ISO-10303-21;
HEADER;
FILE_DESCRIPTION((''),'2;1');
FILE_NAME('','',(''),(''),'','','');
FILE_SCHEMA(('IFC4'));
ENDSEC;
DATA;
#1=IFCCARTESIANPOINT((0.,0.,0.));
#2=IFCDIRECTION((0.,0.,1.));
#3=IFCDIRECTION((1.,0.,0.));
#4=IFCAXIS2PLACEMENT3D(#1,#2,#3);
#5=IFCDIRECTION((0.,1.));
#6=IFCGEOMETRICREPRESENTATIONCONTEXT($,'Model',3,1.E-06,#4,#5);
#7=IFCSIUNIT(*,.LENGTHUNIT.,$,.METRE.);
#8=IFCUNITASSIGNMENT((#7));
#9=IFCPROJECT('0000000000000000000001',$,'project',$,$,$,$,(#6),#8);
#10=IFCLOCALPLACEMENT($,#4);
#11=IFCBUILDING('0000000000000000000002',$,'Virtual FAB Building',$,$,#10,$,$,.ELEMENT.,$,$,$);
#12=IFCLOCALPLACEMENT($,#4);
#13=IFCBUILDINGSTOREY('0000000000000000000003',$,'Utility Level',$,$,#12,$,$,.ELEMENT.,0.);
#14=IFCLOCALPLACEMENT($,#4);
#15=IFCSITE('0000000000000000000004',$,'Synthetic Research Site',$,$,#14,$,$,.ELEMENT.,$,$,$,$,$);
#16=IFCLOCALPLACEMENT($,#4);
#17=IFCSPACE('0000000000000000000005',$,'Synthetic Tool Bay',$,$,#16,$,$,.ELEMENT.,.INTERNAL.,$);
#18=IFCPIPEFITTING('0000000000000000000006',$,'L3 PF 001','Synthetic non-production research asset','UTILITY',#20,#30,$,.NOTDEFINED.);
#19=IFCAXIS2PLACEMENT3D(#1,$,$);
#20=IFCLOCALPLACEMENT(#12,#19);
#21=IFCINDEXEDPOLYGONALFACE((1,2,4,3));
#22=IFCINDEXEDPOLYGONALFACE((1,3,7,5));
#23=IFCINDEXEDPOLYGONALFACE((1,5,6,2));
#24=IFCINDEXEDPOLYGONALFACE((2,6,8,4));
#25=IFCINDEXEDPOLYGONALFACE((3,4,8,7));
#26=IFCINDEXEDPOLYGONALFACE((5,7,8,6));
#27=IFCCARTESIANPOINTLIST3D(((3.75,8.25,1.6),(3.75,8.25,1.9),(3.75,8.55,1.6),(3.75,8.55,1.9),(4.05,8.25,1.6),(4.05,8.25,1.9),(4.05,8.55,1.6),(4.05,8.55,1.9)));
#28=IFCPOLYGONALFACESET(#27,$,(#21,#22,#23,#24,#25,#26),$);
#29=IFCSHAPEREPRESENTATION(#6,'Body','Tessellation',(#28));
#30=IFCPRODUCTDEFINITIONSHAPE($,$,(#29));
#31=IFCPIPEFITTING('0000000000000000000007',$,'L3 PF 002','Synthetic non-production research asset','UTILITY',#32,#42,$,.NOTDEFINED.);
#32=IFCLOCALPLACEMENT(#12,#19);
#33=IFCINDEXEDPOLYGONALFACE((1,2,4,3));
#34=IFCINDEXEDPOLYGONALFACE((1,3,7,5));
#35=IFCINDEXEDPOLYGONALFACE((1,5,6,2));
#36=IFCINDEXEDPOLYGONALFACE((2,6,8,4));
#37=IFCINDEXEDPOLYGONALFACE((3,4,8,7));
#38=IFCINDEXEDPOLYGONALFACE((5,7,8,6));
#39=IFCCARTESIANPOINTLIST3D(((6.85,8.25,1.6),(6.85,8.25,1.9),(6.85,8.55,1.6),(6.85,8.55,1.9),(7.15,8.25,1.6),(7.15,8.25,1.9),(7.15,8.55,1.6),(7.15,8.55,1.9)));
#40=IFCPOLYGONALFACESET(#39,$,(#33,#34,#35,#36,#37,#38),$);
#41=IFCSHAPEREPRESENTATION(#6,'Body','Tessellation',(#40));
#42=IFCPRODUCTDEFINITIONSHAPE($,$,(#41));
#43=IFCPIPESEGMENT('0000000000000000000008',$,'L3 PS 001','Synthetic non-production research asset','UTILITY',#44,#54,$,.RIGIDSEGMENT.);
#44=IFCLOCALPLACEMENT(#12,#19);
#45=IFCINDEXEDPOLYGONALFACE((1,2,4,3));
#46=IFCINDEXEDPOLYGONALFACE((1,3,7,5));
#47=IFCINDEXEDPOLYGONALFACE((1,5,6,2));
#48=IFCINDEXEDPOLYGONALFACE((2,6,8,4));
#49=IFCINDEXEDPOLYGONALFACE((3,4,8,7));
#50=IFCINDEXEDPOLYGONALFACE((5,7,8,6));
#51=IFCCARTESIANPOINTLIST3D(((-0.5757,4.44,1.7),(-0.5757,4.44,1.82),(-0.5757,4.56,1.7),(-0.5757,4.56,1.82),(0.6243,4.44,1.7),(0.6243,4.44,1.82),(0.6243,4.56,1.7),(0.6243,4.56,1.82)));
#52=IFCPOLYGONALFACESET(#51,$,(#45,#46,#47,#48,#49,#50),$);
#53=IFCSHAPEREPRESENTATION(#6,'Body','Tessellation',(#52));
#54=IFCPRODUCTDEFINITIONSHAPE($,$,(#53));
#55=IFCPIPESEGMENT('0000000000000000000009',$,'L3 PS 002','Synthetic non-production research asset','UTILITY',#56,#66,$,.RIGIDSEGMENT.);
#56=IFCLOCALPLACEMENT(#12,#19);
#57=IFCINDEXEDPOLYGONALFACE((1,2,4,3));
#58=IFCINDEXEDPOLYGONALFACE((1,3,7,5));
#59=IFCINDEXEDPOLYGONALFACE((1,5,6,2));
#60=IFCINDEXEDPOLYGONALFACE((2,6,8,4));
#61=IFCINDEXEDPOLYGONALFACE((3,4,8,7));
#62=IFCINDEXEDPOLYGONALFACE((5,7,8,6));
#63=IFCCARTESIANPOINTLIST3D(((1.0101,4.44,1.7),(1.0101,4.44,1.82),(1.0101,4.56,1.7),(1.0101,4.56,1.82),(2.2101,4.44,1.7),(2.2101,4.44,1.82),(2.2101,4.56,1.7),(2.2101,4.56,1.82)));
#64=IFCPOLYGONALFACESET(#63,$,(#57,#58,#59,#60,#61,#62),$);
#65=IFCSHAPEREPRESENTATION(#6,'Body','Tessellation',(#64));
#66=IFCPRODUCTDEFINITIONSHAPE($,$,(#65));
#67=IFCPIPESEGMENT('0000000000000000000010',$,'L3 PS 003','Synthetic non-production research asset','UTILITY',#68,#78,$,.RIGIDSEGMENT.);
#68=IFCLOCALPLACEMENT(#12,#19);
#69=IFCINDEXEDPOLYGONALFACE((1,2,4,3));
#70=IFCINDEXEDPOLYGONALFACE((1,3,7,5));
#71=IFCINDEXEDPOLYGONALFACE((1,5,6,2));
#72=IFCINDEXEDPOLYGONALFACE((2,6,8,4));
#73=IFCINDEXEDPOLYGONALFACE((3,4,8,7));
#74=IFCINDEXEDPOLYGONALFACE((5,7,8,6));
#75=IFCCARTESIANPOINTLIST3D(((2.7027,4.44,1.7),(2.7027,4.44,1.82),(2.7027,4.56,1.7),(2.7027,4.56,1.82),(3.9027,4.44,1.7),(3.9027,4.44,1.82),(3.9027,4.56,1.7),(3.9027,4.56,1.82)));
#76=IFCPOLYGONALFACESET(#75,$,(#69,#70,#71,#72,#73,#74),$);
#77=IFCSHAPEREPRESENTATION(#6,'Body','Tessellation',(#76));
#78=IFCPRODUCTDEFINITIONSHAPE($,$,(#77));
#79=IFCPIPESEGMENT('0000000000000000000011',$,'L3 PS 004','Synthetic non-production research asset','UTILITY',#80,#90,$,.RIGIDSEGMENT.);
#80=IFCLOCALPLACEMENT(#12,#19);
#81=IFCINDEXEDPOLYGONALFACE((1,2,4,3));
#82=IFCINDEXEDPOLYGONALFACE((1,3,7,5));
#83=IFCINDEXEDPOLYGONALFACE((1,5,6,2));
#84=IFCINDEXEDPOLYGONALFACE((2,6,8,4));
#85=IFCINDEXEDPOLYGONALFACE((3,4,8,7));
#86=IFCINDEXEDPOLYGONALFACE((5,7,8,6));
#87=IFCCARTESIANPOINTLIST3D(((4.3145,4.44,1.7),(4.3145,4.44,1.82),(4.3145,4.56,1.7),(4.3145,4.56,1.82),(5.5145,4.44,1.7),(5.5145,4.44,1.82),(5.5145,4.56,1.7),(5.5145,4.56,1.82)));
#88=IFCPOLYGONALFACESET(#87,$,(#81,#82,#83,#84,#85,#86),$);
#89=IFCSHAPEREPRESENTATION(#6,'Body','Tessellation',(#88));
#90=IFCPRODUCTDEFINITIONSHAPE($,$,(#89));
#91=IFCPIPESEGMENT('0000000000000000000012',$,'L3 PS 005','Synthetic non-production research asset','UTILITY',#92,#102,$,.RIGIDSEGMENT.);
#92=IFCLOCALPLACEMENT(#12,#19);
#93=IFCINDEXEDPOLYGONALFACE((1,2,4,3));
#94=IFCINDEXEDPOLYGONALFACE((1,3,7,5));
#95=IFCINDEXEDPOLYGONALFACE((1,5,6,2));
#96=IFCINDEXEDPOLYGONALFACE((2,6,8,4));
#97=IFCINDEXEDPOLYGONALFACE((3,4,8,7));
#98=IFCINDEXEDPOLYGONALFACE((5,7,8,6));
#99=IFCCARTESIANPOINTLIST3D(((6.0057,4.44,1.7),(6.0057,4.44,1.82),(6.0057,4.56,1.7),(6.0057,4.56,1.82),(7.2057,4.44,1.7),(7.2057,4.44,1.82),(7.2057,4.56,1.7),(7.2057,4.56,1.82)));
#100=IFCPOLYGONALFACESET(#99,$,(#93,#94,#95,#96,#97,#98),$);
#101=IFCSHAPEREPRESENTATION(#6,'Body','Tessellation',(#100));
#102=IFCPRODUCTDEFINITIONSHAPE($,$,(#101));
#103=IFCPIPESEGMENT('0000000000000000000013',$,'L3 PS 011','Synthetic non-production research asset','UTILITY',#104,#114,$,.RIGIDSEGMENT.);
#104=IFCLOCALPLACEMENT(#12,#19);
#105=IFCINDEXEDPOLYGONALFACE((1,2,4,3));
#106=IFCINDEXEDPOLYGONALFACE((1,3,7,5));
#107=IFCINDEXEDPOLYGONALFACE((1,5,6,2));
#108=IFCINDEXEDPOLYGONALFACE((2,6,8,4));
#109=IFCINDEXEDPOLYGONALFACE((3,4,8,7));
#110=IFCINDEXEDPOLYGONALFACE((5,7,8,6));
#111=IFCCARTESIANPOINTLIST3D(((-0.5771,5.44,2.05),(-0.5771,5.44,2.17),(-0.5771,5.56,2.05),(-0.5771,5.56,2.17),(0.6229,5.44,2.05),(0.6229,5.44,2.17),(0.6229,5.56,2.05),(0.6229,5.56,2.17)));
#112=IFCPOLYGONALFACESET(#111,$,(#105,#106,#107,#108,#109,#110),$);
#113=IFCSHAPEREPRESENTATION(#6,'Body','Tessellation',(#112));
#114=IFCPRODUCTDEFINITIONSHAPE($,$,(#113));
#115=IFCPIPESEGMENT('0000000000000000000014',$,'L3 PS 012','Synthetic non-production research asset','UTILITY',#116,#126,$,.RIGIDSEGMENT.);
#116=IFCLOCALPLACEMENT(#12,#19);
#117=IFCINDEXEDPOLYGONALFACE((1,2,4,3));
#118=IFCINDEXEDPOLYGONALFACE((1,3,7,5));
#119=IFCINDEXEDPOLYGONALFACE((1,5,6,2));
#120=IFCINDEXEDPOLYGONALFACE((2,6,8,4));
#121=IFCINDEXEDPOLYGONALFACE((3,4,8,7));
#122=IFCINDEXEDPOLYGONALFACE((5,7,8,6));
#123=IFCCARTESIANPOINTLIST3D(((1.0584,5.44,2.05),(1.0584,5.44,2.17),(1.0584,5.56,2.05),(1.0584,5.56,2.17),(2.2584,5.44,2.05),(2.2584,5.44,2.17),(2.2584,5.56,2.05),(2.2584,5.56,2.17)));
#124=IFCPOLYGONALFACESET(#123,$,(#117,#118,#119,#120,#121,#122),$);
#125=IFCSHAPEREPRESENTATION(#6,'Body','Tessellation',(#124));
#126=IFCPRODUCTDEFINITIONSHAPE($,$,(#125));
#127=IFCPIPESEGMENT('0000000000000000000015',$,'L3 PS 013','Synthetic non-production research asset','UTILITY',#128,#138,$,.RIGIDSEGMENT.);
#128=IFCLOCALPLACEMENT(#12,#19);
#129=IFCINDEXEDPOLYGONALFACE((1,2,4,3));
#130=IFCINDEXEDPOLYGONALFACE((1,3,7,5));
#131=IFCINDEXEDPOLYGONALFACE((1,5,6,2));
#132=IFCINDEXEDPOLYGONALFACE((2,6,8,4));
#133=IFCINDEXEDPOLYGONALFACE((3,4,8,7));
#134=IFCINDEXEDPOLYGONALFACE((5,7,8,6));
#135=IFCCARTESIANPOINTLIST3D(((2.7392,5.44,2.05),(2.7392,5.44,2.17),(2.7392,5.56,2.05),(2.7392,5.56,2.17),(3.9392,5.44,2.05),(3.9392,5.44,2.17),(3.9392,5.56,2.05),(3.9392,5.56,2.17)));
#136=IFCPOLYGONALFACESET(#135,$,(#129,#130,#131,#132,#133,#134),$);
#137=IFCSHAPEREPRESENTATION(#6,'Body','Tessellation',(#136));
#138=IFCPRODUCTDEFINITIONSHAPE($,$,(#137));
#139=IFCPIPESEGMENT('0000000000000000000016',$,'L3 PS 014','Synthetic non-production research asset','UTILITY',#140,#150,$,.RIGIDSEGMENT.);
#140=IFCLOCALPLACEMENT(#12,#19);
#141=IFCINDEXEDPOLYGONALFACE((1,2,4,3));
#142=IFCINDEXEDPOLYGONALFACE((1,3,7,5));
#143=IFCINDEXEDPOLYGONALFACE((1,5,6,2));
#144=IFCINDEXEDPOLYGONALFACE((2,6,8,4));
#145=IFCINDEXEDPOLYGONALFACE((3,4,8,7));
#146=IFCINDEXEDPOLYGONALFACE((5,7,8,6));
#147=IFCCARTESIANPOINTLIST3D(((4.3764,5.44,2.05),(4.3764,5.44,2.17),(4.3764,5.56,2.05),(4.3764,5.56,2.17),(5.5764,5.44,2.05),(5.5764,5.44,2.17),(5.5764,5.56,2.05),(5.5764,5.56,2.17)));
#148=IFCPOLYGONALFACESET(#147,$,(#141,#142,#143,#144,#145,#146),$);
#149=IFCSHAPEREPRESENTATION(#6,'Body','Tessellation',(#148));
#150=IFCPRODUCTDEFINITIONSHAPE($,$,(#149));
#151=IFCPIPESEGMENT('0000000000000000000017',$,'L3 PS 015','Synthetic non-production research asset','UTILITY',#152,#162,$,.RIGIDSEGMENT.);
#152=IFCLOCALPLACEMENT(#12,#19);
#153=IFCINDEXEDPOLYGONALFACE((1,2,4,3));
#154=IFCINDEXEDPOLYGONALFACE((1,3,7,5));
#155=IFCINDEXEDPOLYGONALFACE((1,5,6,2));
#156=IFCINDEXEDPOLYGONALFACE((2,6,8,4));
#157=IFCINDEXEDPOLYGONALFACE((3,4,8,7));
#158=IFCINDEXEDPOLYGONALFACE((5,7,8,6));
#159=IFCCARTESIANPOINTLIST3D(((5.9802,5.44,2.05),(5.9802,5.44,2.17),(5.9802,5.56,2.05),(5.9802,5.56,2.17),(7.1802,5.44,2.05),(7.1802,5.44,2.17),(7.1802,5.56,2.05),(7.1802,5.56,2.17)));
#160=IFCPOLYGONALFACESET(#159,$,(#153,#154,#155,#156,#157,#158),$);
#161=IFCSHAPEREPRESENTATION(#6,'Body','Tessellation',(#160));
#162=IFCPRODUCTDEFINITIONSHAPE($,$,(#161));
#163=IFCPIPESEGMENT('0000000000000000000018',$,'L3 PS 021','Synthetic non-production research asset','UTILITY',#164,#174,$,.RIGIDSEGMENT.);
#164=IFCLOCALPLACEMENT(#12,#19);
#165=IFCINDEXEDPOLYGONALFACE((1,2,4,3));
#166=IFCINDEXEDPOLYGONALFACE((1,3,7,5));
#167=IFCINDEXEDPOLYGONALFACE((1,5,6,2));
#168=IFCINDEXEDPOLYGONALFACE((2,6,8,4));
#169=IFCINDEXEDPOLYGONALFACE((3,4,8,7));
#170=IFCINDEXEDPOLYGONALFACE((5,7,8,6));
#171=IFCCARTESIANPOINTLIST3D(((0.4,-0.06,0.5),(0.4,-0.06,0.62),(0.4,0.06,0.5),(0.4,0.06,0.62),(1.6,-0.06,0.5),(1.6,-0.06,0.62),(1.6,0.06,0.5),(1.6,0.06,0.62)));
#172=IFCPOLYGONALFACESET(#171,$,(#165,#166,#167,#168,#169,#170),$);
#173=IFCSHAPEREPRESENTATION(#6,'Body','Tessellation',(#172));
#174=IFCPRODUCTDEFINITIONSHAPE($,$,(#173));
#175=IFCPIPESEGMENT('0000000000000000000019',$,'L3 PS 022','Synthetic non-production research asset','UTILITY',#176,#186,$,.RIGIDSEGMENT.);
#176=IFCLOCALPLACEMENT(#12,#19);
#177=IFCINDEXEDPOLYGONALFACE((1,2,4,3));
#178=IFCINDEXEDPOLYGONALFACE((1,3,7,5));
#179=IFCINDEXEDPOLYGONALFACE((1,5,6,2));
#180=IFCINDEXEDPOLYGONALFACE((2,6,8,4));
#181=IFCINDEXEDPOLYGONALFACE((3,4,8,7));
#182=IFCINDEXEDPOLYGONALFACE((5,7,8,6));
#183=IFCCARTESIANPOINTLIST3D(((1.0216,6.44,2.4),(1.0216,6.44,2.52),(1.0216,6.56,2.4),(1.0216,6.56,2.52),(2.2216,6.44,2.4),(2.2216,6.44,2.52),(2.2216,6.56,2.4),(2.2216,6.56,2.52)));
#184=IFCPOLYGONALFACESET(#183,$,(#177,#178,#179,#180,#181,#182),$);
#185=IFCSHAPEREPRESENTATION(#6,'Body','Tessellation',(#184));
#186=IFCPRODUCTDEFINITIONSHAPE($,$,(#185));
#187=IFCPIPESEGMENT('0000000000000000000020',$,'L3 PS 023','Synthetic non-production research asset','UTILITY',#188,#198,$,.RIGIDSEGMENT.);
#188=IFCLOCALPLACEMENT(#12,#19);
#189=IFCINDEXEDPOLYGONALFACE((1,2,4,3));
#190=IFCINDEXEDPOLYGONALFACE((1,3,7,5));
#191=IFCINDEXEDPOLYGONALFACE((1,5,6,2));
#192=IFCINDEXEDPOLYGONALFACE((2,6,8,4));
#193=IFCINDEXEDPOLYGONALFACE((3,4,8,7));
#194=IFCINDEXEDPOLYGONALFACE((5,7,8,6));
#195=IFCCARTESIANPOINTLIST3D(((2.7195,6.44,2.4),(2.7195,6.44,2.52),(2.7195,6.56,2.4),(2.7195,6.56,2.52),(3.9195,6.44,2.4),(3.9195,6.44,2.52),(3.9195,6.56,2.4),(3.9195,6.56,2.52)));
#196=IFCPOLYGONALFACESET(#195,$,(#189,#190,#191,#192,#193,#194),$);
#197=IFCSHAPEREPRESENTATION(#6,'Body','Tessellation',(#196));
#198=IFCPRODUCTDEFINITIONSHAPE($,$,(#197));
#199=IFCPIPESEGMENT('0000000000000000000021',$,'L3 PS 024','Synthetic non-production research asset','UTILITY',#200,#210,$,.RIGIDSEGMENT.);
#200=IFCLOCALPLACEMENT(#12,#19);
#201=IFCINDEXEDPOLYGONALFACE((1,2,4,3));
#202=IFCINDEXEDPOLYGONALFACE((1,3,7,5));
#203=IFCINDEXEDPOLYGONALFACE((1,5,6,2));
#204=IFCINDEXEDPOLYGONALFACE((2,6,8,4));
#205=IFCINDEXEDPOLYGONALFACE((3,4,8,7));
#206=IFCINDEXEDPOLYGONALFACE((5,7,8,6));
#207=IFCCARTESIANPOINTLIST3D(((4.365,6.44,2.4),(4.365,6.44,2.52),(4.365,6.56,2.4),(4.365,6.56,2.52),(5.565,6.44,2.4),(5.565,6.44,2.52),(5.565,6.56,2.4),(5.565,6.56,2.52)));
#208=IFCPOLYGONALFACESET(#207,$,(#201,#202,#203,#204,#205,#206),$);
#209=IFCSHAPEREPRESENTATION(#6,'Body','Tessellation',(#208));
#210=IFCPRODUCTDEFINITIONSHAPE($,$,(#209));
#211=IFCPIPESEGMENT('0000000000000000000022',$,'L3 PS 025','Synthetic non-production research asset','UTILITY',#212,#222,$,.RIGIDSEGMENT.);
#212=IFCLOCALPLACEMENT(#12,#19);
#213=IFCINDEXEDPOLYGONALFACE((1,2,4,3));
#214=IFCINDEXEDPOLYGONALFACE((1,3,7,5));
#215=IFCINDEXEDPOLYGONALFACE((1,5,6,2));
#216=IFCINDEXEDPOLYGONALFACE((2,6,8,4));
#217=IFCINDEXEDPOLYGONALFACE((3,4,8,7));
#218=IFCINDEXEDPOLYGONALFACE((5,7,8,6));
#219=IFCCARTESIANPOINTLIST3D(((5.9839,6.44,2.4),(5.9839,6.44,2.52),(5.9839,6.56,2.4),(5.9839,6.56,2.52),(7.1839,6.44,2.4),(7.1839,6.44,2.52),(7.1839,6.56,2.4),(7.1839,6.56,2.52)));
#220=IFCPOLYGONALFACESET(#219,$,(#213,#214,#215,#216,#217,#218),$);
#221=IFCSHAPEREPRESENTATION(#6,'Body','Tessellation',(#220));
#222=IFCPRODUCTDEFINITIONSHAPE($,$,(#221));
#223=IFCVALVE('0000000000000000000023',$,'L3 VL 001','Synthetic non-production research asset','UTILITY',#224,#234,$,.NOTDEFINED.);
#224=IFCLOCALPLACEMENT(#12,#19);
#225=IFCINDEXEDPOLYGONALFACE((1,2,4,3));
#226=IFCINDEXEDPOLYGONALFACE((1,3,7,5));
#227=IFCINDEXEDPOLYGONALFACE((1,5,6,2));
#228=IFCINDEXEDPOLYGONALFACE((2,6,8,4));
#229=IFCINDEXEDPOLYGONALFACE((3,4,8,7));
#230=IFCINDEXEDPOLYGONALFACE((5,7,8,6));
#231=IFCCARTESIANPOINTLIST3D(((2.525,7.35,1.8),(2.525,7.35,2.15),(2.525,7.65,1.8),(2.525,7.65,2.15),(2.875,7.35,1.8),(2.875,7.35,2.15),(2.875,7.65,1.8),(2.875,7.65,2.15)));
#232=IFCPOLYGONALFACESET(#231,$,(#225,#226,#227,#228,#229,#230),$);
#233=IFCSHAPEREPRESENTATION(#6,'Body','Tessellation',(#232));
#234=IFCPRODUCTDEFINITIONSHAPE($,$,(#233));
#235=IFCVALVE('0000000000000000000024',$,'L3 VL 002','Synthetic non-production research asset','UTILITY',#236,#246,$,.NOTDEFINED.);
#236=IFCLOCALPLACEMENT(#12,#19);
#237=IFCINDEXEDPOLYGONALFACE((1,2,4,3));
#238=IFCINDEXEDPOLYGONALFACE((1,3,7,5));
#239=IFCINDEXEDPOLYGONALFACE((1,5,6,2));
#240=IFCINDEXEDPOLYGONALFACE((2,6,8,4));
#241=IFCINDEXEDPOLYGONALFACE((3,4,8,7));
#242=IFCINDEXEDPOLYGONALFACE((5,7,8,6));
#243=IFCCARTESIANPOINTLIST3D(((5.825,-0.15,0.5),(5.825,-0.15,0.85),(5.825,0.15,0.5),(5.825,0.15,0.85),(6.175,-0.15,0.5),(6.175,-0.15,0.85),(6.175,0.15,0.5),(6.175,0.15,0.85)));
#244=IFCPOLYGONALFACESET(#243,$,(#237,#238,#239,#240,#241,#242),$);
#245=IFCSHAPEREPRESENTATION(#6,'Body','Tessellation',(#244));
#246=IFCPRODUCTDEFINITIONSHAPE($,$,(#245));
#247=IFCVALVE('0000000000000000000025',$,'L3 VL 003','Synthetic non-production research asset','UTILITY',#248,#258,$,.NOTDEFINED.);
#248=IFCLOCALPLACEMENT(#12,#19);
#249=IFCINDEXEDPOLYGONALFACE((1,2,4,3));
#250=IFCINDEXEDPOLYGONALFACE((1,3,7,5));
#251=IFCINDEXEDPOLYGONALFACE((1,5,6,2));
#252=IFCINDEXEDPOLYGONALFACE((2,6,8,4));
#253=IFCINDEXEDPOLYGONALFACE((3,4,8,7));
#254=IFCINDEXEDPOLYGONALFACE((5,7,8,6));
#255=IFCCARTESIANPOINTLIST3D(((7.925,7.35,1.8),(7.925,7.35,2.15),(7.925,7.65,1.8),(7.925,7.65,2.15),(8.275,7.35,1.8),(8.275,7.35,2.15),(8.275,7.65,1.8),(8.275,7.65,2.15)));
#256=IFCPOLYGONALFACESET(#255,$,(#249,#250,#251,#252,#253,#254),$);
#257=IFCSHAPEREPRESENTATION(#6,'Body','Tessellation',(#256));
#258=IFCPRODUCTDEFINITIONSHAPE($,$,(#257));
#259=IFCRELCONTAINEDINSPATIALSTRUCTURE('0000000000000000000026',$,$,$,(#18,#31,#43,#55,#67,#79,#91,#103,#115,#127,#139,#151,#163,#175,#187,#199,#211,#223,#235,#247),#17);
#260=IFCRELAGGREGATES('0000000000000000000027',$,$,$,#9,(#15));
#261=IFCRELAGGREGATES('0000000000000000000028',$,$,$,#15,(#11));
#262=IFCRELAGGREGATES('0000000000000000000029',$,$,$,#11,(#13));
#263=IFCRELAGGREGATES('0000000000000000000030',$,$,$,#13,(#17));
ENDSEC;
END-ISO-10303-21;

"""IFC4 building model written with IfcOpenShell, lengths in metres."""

from ifc_helpers import new_model, si_unit, direction, frame, origin_with_axes, origin_2d_with_axis, place, context, project, spatial, rectangle, extrude, element, save


model = new_model("IFC4")

# Units and contexts
model_context = context("Model", 3, precision=1e-06, world=origin_with_axes(), true_north=direction((0.0, 1.0)))
ifc_project = project(units=[si_unit("LENGTHUNIT", "METRE")], contexts=[model_context])

# Site, building, storey, space
site_placement = place(None, origin_with_axes())
site = spatial("IfcSite", under=ifc_project, at=site_placement, Name="Synthetic Research Site", CompositionType="ELEMENT")
building_placement = place(None, origin_with_axes())
building = spatial("IfcBuilding", under=site, at=building_placement, Name="Virtual FAB Building", CompositionType="ELEMENT")
storey_placement = place(None, origin_with_axes())
storey = spatial("IfcBuildingStorey", under=building, at=storey_placement, Name="Utility Level", CompositionType="ELEMENT", Elevation=0.0)
space_placement = place(None, origin_with_axes())
space = spatial("IfcSpace", under=storey, at=space_placement, Name="Synthetic Tool Bay", CompositionType="ELEMENT", PredefinedType="INTERNAL")

# Pipe fittings
for number, where, z_axis, x_axis, name in (
    (1, (3.9, 8.4, 1.6), (0.0, 0.0, 1.0), (1.0, 0.0, 0.0), "L3 PF 001"),
    (2, (7.0, 8.4, 1.6), (0.0, 0.0, 1.0), (1.0, 0.0, 0.0), "L3 PF 002"),
):
    element("IfcPipeFitting", number, at=place(None, frame(where, z_axis=z_axis, x_axis=x_axis)), inside=space, Name=name, Description="Synthetic non-production research asset", ObjectType="UTILITY", PredefinedType="NOTDEFINED", context=model_context, shape_type="SweptSolid", body=[
        extrude(rectangle(XDim=0.3, YDim=0.3, at=origin_2d_with_axis()), origin_with_axes(), (0.0, 0.0, 1.0), 0.3),
    ])

# Pipe segments
for number, where, z_axis, x_axis, name in (
    (3, (0.0243, 4.5, 1.7), (0.0, 0.0, 1.0), (1.0, 0.0, 0.0), "L3 PS 001"),
    (4, (1.6101, 4.5, 1.7), (0.0, 0.0, 1.0), (1.0, 0.0, 0.0), "L3 PS 002"),
    (5, (3.3027, 4.5, 1.7), (0.0, 0.0, 1.0), (1.0, 0.0, 0.0), "L3 PS 003"),
    (6, (4.9145, 4.5, 1.7), (0.0, 0.0, 1.0), (1.0, 0.0, 0.0), "L3 PS 004"),
    (7, (6.6057, 4.5, 1.7), (0.0, 0.0, 1.0), (1.0, 0.0, 0.0), "L3 PS 005"),
    (8, (0.0229, 5.5, 2.05), (0.0, 0.0, 1.0), (1.0, 0.0, 0.0), "L3 PS 011"),
    (9, (1.6584, 5.5, 2.05), (0.0, 0.0, 1.0), (1.0, 0.0, 0.0), "L3 PS 012"),
    (10, (3.3392, 5.5, 2.05), (0.0, 0.0, 1.0), (1.0, 0.0, 0.0), "L3 PS 013"),
    (11, (4.9764, 5.5, 2.05), (0.0, 0.0, 1.0), (1.0, 0.0, 0.0), "L3 PS 014"),
    (12, (6.5802, 5.5, 2.05), (0.0, 0.0, 1.0), (1.0, 0.0, 0.0), "L3 PS 015"),
    (13, (1.0, 0.0, 0.5), (0.0, 0.0, 1.0), (1.0, 0.0, 0.0), "L3 PS 021"),
    (14, (1.6216, 6.5, 2.4), (0.0, 0.0, 1.0), (1.0, 0.0, 0.0), "L3 PS 022"),
    (15, (3.3195, 6.5, 2.4), (0.0, 0.0, 1.0), (1.0, 0.0, 0.0), "L3 PS 023"),
    (16, (4.965, 6.5, 2.4), (0.0, 0.0, 1.0), (1.0, 0.0, 0.0), "L3 PS 024"),
    (17, (6.5839, 6.5, 2.4), (0.0, 0.0, 1.0), (1.0, 0.0, 0.0), "L3 PS 025"),
):
    element("IfcPipeSegment", number, at=place(None, frame(where, z_axis=z_axis, x_axis=x_axis)), inside=space, Name=name, Description="Synthetic non-production research asset", ObjectType="UTILITY", PredefinedType="RIGIDSEGMENT", context=model_context, shape_type="SweptSolid", body=[
        extrude(rectangle(XDim=1.2, YDim=0.12, at=origin_2d_with_axis()), origin_with_axes(), (0.0, 0.0, 1.0), 0.12),
    ])

# Valves
for number, where, z_axis, x_axis, name in (
    (18, (2.7, 7.5, 1.8), (0.0, 0.0, 1.0), (1.0, 0.0, 0.0), "L3 VL 001"),
    (19, (6.0, 0.0, 0.5), (0.0, 0.0, 1.0), (1.0, 0.0, 0.0), "L3 VL 002"),
    (20, (8.1, 7.5, 1.8), (0.0, 0.0, 1.0), (1.0, 0.0, 0.0), "L3 VL 003"),
):
    element("IfcValve", number, at=place(None, frame(where, z_axis=z_axis, x_axis=x_axis)), inside=space, Name=name, Description="Synthetic non-production research asset", ObjectType="UTILITY", PredefinedType="NOTDEFINED", context=model_context, shape_type="SweptSolid", body=[
        extrude(rectangle(XDim=0.35, YDim=0.3, at=origin_2d_with_axis()), origin_with_axes(), (0.0, 0.0, 1.0), 0.35),
    ])

save(model, "model.ifc")
